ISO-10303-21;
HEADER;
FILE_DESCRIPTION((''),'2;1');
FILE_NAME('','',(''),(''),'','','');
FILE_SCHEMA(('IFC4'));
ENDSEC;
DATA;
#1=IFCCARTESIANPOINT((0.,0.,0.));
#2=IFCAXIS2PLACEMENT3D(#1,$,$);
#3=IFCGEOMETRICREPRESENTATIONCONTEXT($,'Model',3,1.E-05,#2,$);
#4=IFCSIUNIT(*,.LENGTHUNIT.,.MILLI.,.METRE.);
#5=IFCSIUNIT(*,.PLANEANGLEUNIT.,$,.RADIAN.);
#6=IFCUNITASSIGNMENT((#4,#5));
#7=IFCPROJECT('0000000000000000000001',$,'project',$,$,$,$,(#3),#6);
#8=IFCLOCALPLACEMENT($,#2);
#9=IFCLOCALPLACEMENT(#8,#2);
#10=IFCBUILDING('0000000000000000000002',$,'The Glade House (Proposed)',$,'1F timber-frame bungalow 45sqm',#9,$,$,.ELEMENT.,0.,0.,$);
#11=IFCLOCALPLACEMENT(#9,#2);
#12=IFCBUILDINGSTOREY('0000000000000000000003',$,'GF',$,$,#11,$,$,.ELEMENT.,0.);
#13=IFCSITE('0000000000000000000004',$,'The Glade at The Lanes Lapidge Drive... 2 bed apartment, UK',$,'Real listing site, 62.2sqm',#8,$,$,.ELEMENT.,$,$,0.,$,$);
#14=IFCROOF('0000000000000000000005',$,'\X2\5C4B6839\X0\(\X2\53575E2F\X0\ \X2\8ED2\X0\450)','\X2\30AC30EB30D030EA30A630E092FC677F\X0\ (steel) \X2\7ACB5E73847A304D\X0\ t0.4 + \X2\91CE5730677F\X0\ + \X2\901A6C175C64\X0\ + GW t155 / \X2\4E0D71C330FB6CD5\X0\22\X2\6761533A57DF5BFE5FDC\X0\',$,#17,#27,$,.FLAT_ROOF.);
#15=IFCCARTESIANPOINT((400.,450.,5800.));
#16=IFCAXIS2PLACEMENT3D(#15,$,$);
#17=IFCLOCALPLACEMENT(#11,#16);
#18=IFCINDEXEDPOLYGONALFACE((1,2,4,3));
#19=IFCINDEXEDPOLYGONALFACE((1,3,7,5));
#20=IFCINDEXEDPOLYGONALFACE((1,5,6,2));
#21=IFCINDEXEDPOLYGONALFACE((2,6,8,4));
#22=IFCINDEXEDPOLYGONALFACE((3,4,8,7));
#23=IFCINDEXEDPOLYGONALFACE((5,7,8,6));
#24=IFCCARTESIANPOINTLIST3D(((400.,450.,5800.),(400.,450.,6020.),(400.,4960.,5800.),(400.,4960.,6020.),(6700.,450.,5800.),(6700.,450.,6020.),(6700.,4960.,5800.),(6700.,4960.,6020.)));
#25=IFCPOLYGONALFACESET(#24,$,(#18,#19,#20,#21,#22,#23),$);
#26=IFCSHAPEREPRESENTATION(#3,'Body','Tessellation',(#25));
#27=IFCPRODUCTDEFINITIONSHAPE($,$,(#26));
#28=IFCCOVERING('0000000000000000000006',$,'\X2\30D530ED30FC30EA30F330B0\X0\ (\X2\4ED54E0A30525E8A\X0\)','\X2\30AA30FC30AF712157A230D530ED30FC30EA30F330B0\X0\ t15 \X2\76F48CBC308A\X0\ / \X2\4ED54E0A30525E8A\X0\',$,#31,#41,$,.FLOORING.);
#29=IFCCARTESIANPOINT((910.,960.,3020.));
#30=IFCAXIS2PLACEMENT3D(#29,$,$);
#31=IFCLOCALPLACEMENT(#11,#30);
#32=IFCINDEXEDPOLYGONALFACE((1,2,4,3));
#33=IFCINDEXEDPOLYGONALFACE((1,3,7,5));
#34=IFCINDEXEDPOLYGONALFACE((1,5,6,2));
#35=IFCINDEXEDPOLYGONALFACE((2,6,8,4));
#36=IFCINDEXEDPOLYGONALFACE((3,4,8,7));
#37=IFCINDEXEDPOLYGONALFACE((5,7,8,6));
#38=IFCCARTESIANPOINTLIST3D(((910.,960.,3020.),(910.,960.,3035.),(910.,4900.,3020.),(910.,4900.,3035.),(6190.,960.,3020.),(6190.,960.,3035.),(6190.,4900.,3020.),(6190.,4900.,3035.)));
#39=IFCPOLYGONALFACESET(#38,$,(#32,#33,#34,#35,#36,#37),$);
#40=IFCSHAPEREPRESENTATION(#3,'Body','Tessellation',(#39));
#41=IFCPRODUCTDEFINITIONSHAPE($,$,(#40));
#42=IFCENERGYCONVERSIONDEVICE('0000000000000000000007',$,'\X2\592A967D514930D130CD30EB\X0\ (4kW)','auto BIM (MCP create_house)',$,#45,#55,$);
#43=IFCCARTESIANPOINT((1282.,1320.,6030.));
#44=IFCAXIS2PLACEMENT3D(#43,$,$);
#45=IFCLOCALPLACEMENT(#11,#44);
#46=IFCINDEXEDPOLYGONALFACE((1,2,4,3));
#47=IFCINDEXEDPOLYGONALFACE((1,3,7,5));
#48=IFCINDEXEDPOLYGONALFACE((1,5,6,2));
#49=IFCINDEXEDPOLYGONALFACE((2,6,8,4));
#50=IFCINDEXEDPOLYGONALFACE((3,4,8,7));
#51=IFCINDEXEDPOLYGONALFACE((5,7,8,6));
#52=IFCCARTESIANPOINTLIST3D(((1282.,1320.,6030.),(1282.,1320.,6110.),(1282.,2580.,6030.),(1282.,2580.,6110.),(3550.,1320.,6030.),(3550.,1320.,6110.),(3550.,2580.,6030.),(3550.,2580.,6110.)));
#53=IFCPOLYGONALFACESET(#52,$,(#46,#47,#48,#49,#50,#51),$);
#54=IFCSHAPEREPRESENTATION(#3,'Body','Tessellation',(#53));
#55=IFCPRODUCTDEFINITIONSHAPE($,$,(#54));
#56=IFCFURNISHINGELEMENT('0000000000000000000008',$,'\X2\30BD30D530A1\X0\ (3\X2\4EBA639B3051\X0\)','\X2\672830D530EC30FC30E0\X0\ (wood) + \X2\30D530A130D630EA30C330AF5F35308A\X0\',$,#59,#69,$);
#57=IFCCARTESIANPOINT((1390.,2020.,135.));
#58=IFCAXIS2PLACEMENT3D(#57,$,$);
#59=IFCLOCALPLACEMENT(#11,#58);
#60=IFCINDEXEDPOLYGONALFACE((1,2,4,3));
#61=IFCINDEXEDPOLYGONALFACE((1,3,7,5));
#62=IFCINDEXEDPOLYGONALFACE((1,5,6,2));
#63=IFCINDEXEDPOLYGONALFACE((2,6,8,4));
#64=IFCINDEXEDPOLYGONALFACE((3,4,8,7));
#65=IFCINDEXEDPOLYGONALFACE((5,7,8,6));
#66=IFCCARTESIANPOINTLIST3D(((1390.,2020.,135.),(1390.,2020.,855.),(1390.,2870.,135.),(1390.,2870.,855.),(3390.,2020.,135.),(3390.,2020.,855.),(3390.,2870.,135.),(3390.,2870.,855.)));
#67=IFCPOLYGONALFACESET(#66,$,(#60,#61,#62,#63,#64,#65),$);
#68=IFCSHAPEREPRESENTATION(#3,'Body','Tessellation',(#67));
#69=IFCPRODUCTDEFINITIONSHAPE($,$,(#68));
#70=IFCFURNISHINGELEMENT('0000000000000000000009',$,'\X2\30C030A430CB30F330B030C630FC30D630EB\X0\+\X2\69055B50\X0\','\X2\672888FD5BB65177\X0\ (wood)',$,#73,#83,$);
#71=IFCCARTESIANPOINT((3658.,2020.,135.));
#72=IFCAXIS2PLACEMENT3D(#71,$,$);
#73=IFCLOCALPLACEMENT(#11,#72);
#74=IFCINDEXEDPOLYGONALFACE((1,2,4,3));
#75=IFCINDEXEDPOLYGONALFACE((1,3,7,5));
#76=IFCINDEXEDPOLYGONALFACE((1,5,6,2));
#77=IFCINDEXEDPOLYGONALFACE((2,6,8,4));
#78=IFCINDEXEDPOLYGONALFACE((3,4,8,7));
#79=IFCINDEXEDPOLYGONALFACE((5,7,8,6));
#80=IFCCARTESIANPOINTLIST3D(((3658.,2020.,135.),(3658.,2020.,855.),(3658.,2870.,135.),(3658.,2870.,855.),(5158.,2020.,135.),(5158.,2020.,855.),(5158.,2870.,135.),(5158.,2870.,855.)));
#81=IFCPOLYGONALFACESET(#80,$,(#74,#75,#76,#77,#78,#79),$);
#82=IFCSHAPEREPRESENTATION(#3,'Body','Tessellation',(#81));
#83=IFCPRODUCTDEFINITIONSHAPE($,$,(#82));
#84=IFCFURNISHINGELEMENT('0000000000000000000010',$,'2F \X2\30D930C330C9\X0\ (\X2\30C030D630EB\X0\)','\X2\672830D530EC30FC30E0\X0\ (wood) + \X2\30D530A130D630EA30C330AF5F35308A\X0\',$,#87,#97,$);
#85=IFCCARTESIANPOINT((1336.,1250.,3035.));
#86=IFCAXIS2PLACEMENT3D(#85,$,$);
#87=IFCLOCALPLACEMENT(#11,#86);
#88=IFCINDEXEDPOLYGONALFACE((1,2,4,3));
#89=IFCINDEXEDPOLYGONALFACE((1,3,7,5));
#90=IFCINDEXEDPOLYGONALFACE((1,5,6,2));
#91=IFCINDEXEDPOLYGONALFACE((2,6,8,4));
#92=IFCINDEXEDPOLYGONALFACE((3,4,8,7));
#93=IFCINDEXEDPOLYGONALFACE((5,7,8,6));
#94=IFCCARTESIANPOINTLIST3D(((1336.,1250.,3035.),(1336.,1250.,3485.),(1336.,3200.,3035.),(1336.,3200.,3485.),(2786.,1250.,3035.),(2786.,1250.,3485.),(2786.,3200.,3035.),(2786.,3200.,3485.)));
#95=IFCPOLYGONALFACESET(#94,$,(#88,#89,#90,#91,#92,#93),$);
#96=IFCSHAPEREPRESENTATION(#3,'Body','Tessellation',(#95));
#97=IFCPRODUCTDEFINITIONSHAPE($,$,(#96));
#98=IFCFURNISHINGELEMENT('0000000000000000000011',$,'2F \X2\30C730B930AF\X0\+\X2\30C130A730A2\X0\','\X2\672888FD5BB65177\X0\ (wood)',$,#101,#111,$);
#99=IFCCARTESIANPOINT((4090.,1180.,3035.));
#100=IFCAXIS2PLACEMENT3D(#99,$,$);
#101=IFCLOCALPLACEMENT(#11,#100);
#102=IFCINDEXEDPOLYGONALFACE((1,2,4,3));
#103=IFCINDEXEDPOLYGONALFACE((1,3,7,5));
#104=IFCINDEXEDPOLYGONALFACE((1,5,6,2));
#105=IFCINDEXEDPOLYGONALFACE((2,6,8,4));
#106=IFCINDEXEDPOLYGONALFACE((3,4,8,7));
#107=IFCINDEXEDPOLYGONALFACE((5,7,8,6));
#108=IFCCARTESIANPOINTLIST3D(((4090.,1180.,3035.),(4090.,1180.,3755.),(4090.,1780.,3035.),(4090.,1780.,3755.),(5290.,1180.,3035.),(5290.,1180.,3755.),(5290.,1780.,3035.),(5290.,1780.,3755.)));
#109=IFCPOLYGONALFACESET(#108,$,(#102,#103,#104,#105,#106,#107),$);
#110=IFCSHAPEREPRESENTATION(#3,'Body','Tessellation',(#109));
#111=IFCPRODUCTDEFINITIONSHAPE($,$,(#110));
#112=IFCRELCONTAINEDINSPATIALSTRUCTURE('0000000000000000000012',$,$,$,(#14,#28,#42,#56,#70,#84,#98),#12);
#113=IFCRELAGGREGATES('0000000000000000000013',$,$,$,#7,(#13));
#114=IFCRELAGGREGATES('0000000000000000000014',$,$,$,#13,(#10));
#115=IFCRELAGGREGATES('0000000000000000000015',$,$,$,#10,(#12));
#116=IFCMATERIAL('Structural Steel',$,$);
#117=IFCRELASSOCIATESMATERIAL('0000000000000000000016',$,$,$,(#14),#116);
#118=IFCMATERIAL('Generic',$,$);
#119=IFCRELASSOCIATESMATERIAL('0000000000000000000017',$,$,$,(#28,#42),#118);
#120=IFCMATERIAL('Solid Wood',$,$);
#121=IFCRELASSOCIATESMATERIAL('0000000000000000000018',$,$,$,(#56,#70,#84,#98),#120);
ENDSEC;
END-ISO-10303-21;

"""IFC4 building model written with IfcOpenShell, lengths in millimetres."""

from ifc_helpers import new_model, si_unit, frame, frame_2d, origin, place, context, project, spatial, rectangle, extrude, material, element, save


model = new_model("IFC4")

# Units and contexts
model_context = context("Model", 3, precision=1e-05, world=origin())
ifc_project = project(units=[si_unit("LENGTHUNIT", "METRE", prefix="MILLI"), si_unit("PLANEANGLEUNIT", "RADIAN")], contexts=[model_context])

# Site, building, storey
site_placement = place(None, origin())
site = spatial("IfcSite", under=ifc_project, at=site_placement, Name="The Glade at The Lanes Lapidge Drive... 2 bed apartment, UK", ObjectType="Real listing site, 62.2sqm", CompositionType="ELEMENT", RefElevation=0.0)
building_placement = place(site_placement, origin())
building = spatial("IfcBuilding", under=site, at=building_placement, Name="The Glade House (Proposed)", ObjectType="1F timber-frame bungalow 45sqm", CompositionType="ELEMENT", ElevationOfRefHeight=0.0, ElevationOfTerrain=0.0)
storey_placement = place(building_placement, origin())
storey = spatial("IfcBuildingStorey", under=building, at=storey_placement, Name="GF", CompositionType="ELEMENT", Elevation=0.0)

# Shared definitions
ifc_material_1 = material(Name="Solid Wood")

# Shared definitions
ifc_material_2 = material(Name="Generic")

# Roof
ifc_material_3 = material(Name="Structural Steel")
for number, where, name in (
    (1, (400.0, 450.0, 5800.0), "屋根(南帯 軒450)"),
):
    element("IfcRoof", number, at=place(storey_placement, frame(where)), inside=storey, material=ifc_material_3, Name=name, Description="ガルバリウム鋼板 (steel) 立平葺き t0.4 + 野地板 + 通気層 + GW t155 / 不燃・法22条区域対応", PredefinedType="FLAT_ROOF", context=model_context, shape_type="SweptSolid", body=[
        extrude(rectangle(XDim=6300.0, YDim=4510.0, at=frame_2d((3150.0, 2255.0))), frame((400.0, 450.0, 5800.0)), (0.0, 0.0, 1.0), 220.0),
    ])

# Covering
covering_placement = place(storey_placement, frame((910.0, 960.0, 3020.0)))
element("IfcCovering", 2, at=covering_placement, inside=storey, material=ifc_material_2, Name="フローリング (仕上げ床)", Description="オーク無垢フローリング t15 直貼り / 仕上げ床", PredefinedType="FLOORING", context=model_context, shape_type="SweptSolid", body=[
    extrude(rectangle(XDim=5280.0, YDim=3940.0, at=frame_2d((2640.0, 1970.0))), frame((910.0, 960.0, 3020.0)), (0.0, 0.0, 1.0), 15.0),
])

# Energy conversion device
energy_conversion_device_placement = place(storey_placement, frame((1282.0, 1320.0, 6030.0)))
element("IfcEnergyConversionDevice", 3, at=energy_conversion_device_placement, inside=storey, material=ifc_material_2, Name="太陽光パネル (4kW)", Description="auto BIM (MCP create_house)", context=model_context, shape_type="SweptSolid", body=[
    extrude(rectangle(XDim=2268.0, YDim=1260.0, at=frame_2d((1134.0, 630.0))), frame((1282.0, 1320.0, 6030.0)), (0.0, 0.0, 1.0), 80.0),
])

# Furnishing elements
furnishing_1_placement = place(storey_placement, frame((1390.0, 2020.0, 135.0)))
element("IfcFurnishingElement", 4, at=furnishing_1_placement, inside=storey, material=ifc_material_1, Name="ソファ (3人掛け)", Description="木フレーム (wood) + ファブリック張り", context=model_context, shape_type="SweptSolid", body=[
    extrude(rectangle(XDim=2000.0, YDim=850.0, at=frame_2d((1000.0, 425.0))), frame((1390.0, 2020.0, 135.0)), (0.0, 0.0, 1.0), 720.0),
])
furnishing_2_placement = place(storey_placement, frame((3658.0, 2020.0, 135.0)))
element("IfcFurnishingElement", 5, at=furnishing_2_placement, inside=storey, material=ifc_material_1, Name="ダイニングテーブル+椅子", Description="木製家具 (wood)", context=model_context, shape_type="SweptSolid", body=[
    extrude(rectangle(XDim=1500.0, YDim=850.0, at=frame_2d((750.0, 425.0))), frame((3658.0, 2020.0, 135.0)), (0.0, 0.0, 1.0), 720.0),
])
furnishing_3_placement = place(storey_placement, frame((1336.0, 1250.0, 3035.0)))
element("IfcFurnishingElement", 6, at=furnishing_3_placement, inside=storey, material=ifc_material_1, Name="2F ベッド (ダブル)", Description="木フレーム (wood) + ファブリック張り", context=model_context, shape_type="SweptSolid", body=[
    extrude(rectangle(XDim=1450.0, YDim=1950.0, at=frame_2d((725.0, 975.0))), frame((1336.0, 1250.0, 3035.0)), (0.0, 0.0, 1.0), 450.0),
])
furnishing_4_placement = place(storey_placement, frame((4090.0, 1180.0, 3035.0)))
element("IfcFurnishingElement", 7, at=furnishing_4_placement, inside=storey, material=ifc_material_1, Name="2F デスク+チェア", Description="木製家具 (wood)", context=model_context, shape_type="SweptSolid", body=[
    extrude(rectangle(XDim=1200.0, YDim=600.0, at=frame_2d((600.0, 300.0))), frame((4090.0, 1180.0, 3035.0)), (0.0, 0.0, 1.0), 720.0),
])

save(model, "model.ifc")
